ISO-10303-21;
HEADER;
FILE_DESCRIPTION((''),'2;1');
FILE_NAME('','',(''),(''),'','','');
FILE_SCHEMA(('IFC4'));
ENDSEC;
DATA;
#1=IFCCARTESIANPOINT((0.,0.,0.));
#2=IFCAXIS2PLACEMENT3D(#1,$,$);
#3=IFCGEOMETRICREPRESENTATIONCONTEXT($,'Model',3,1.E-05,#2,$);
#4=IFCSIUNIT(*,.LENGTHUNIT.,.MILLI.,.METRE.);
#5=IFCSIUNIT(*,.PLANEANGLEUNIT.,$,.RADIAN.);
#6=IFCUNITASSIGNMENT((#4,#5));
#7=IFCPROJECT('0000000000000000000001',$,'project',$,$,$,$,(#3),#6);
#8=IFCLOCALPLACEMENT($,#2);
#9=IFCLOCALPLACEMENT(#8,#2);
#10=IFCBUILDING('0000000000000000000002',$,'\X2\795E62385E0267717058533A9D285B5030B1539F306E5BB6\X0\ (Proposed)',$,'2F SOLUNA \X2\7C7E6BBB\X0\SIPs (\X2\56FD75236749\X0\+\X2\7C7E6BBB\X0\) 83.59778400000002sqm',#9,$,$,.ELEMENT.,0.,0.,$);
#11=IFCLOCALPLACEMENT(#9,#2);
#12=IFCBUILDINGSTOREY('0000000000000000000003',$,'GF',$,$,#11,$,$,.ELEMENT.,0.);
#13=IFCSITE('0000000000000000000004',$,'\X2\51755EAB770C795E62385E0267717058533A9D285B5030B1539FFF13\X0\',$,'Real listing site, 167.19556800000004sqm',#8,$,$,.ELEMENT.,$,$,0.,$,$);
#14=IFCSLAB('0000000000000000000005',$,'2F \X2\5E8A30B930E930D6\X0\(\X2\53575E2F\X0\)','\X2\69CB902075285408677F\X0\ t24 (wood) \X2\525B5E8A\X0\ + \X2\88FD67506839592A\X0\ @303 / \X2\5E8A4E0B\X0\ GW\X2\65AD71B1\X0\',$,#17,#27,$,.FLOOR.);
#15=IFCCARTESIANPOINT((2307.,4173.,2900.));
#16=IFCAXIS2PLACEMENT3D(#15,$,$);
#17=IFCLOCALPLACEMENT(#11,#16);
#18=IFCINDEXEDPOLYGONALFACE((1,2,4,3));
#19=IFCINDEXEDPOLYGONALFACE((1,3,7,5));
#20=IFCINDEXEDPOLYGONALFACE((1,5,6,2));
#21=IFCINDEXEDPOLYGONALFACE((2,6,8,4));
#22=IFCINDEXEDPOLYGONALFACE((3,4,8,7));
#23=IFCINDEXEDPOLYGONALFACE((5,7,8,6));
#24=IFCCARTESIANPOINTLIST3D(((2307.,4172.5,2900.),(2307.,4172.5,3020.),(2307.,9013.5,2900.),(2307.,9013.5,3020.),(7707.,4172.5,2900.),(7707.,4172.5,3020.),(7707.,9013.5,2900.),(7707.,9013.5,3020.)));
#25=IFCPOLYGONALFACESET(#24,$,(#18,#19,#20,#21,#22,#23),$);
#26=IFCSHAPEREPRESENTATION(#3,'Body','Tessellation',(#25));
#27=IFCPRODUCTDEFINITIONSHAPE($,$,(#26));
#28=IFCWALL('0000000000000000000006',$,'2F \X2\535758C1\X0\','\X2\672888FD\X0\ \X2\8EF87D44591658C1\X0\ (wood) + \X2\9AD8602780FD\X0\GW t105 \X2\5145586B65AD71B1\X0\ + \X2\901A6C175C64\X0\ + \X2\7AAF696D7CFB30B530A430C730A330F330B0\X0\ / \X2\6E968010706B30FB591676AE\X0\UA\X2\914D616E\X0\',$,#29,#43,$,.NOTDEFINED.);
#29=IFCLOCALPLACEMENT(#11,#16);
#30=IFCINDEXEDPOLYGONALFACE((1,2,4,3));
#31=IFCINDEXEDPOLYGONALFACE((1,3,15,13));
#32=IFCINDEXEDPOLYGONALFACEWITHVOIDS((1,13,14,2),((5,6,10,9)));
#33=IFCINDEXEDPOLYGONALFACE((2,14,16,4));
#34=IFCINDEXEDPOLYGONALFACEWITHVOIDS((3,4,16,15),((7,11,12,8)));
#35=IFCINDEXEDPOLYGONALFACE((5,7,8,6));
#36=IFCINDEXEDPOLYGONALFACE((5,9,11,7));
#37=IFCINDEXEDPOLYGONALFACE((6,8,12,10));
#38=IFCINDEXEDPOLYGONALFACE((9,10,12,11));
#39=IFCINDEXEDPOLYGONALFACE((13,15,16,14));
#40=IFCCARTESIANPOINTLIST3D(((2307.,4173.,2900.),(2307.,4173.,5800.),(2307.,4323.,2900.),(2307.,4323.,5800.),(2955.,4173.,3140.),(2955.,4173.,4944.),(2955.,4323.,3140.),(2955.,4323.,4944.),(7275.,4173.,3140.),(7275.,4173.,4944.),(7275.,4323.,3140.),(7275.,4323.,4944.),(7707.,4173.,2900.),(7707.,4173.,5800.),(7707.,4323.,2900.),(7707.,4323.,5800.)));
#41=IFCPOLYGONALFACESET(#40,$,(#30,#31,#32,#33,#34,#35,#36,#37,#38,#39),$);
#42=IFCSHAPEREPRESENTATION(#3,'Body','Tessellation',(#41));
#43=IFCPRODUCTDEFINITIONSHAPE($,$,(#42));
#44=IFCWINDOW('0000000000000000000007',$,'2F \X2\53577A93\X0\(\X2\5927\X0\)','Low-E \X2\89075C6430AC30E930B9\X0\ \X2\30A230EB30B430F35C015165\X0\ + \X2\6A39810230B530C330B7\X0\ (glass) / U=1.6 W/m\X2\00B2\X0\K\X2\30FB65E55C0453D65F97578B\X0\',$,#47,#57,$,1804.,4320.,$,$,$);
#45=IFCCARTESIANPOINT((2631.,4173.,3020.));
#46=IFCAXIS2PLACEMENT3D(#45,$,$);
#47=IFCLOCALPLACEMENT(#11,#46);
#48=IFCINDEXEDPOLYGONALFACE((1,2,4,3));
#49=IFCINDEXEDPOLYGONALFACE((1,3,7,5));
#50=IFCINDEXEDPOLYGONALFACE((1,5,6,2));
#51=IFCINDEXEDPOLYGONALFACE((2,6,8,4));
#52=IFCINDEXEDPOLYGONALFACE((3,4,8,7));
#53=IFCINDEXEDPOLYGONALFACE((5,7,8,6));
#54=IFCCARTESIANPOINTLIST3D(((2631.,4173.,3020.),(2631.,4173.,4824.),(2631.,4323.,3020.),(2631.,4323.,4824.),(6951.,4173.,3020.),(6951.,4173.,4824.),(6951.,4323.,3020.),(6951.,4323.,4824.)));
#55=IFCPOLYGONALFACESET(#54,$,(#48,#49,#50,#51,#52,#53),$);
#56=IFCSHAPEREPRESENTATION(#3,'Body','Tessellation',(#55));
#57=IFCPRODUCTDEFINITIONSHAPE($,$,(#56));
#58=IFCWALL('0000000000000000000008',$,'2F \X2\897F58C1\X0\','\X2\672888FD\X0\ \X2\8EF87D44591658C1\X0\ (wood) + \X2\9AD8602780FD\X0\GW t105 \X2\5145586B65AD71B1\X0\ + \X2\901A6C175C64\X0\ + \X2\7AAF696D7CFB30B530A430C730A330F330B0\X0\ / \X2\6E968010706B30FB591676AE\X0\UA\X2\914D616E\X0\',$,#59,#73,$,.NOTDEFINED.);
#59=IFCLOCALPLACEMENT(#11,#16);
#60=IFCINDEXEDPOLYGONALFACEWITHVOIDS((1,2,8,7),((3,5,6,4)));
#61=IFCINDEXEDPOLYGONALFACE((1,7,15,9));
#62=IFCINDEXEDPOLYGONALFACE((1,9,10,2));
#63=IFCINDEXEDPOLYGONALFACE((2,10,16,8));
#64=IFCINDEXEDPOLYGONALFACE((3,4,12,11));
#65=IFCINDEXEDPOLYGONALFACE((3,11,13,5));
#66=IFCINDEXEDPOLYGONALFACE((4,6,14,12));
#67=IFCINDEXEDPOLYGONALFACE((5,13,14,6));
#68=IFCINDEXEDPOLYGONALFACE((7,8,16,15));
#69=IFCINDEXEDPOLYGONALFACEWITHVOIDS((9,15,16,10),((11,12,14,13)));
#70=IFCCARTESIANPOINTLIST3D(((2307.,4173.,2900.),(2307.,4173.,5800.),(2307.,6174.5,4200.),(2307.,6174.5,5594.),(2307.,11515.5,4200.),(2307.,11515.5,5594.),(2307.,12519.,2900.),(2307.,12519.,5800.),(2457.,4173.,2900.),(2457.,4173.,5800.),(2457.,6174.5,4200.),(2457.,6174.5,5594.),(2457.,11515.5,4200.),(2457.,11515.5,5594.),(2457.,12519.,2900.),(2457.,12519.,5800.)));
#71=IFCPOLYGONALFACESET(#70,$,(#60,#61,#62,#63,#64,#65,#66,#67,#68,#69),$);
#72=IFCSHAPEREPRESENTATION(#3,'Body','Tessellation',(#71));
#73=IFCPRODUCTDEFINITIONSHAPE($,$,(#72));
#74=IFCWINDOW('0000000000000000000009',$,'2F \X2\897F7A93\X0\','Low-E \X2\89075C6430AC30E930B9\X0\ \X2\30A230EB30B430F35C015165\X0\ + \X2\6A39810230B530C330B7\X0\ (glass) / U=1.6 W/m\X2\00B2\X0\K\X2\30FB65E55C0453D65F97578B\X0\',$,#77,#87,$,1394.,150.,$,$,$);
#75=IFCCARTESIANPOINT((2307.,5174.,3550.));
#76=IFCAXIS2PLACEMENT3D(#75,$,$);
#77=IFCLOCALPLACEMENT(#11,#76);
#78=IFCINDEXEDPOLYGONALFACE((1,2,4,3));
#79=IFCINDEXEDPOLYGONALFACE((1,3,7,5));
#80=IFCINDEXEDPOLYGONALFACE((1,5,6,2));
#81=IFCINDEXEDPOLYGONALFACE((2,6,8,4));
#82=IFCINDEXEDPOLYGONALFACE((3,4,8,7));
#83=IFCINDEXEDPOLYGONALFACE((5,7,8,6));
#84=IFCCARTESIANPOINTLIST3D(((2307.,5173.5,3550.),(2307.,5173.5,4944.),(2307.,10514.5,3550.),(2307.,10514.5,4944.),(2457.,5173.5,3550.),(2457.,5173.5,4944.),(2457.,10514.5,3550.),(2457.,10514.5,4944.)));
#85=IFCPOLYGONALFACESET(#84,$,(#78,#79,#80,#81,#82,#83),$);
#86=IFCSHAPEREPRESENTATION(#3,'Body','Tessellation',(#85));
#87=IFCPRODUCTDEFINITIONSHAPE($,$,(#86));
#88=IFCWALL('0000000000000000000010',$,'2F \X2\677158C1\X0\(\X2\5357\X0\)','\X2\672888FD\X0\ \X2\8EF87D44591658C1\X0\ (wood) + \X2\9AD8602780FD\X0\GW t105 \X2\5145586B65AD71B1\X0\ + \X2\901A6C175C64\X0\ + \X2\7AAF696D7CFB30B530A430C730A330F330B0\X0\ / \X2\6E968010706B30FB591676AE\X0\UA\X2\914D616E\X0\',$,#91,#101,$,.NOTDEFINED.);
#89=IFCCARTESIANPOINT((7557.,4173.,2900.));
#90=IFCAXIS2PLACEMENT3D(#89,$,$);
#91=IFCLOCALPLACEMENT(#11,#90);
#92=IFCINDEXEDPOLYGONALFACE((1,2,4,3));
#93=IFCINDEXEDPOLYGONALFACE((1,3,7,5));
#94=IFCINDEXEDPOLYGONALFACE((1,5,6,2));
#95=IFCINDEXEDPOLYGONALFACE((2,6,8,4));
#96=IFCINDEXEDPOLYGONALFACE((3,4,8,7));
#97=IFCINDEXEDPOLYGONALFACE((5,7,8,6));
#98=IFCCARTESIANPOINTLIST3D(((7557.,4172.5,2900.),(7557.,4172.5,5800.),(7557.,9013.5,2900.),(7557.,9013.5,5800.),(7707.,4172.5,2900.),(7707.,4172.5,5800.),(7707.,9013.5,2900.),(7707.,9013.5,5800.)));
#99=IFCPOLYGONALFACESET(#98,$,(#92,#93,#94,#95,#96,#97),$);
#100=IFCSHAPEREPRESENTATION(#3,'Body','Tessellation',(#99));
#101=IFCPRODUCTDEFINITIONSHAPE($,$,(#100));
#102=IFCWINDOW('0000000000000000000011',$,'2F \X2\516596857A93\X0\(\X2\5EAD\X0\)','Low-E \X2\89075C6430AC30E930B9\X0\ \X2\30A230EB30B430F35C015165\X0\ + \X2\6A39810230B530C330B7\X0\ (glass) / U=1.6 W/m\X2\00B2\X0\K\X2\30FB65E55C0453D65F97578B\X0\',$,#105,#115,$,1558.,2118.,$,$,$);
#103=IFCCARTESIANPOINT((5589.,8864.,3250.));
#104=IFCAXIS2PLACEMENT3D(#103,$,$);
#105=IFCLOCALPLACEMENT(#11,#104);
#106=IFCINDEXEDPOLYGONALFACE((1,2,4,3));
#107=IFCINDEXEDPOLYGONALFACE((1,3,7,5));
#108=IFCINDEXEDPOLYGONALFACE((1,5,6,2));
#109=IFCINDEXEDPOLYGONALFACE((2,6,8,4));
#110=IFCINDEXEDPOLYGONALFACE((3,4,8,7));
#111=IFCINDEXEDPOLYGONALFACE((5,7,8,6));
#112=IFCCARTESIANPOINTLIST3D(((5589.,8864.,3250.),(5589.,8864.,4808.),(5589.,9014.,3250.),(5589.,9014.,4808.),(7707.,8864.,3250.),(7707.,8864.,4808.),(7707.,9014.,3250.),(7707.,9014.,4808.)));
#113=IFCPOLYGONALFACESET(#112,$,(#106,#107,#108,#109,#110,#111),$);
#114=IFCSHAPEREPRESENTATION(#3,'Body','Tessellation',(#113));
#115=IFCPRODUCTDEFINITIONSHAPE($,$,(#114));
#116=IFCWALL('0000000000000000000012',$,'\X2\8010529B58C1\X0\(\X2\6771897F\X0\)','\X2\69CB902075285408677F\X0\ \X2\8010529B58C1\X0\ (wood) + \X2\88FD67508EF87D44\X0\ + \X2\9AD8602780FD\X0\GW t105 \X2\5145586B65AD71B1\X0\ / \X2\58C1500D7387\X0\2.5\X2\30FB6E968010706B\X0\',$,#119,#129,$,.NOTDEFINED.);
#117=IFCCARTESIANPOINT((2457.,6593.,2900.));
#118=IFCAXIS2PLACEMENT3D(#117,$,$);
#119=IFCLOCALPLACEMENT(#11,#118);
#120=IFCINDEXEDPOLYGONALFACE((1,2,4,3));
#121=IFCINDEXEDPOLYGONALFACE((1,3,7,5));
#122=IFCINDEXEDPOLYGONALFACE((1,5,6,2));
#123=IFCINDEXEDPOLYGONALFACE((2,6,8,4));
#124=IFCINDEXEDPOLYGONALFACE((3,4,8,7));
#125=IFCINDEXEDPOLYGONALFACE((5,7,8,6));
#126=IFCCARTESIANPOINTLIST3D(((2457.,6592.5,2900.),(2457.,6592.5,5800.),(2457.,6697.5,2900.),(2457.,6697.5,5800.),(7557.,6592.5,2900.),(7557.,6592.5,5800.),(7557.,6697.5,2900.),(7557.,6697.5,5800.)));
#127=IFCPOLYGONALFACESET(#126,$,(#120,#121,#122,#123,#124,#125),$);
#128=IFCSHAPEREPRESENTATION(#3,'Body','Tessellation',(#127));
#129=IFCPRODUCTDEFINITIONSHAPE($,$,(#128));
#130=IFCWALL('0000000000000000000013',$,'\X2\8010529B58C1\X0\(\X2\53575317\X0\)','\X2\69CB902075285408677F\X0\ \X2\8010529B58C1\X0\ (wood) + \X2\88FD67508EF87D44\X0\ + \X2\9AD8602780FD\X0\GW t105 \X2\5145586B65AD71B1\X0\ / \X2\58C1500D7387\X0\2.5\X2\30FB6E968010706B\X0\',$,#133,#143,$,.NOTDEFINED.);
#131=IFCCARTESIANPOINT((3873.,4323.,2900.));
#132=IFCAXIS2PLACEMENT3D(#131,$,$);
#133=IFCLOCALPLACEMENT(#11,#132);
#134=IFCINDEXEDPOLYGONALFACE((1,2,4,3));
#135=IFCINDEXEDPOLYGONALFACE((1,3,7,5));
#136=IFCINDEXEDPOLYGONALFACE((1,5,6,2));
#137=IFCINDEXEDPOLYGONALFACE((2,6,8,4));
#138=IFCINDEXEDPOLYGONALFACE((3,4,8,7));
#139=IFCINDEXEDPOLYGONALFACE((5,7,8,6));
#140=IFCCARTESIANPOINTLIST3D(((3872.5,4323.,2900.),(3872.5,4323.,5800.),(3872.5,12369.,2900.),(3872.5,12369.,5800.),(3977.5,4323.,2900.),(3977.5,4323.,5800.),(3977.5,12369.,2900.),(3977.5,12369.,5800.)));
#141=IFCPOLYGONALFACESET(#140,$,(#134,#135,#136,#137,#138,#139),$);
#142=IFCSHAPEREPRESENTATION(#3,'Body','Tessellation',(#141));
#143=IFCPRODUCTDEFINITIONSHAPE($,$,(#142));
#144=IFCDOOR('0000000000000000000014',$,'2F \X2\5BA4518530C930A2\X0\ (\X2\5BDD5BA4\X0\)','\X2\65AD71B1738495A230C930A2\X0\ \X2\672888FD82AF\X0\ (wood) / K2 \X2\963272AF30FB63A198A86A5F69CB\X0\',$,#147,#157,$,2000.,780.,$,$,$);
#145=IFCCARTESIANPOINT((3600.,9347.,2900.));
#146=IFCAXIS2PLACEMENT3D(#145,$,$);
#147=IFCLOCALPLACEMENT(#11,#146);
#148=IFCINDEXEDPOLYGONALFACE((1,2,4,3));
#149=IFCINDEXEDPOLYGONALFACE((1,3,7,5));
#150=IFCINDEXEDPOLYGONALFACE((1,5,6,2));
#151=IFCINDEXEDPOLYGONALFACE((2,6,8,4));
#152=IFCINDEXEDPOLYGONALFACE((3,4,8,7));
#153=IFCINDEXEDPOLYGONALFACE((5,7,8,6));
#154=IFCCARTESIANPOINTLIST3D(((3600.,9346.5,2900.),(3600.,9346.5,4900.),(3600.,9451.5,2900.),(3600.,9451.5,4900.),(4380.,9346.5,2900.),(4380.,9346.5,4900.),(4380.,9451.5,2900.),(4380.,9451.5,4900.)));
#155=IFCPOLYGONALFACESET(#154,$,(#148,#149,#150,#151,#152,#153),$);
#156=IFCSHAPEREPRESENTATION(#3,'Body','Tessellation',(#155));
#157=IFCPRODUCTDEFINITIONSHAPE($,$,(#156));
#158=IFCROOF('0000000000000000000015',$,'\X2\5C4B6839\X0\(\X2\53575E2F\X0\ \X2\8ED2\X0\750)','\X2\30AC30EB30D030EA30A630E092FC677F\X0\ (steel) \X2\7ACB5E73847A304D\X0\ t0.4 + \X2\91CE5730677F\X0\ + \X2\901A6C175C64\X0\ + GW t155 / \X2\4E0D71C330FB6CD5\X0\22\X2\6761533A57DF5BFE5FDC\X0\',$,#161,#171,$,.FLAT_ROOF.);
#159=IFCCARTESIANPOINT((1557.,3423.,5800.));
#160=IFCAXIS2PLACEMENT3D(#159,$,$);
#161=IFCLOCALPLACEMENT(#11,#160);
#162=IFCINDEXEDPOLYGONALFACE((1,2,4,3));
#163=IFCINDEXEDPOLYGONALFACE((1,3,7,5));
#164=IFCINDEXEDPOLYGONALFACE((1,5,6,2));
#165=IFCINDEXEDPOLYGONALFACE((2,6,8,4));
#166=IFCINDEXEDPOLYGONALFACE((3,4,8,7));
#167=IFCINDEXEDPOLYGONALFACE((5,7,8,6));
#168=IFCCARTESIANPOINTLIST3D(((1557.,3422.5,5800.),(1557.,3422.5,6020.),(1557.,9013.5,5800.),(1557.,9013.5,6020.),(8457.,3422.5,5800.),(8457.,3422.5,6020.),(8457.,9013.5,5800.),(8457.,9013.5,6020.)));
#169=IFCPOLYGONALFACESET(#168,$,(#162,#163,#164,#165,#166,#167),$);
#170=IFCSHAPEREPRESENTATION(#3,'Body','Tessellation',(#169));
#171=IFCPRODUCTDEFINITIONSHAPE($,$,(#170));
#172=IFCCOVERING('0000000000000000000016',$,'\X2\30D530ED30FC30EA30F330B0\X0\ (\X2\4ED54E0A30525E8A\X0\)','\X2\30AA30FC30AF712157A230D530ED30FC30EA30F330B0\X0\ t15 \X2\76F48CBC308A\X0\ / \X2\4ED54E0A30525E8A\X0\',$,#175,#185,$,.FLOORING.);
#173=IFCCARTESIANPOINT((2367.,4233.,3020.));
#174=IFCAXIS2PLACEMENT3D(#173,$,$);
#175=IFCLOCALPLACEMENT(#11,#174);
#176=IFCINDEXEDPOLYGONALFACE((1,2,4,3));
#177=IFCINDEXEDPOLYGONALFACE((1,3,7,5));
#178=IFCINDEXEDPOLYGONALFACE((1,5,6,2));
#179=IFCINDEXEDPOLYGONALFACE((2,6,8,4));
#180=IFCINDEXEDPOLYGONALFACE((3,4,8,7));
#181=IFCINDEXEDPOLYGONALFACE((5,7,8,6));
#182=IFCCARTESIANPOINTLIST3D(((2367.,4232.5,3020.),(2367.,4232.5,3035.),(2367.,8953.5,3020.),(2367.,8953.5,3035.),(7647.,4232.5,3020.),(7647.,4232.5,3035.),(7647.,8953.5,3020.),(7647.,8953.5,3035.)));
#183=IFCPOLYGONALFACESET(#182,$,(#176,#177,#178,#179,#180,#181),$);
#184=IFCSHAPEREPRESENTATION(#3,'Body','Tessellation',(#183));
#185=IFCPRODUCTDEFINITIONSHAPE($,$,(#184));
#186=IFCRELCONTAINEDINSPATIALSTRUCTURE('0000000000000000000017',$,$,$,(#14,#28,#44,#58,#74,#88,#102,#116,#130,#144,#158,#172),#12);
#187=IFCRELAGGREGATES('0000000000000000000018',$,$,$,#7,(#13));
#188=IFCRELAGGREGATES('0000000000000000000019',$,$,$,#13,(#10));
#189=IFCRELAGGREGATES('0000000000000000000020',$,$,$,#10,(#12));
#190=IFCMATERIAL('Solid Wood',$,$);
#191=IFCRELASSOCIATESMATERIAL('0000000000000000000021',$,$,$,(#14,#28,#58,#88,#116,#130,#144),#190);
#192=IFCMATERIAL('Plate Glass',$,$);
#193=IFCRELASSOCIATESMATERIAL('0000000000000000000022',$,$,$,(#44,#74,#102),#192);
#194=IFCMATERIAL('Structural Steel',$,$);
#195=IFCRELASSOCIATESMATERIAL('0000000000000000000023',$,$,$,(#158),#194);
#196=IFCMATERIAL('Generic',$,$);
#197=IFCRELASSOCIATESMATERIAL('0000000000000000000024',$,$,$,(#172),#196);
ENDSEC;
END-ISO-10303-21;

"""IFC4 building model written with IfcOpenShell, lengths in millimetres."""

from ifc_helpers import new_model, si_unit, frame, frame_2d, origin, place, context, project, spatial, rectangle, extrude, material, element, fill, save


model = new_model("IFC4")

# Units and contexts
model_context = context("Model", 3, precision=1e-05, world=origin())
ifc_project = project(units=[si_unit("LENGTHUNIT", "METRE", prefix="MILLI"), si_unit("PLANEANGLEUNIT", "RADIAN")], contexts=[model_context])

# Site, building, storey
site_placement = place(None, origin())
site = spatial("IfcSite", under=ifc_project, at=site_placement, Name="兵庫県神戸市東灘区鴨子ケ原３", ObjectType="Real listing site, 167.19556800000004sqm", CompositionType="ELEMENT", RefElevation=0.0)
building_placement = place(site_placement, origin())
building = spatial("IfcBuilding", under=site, at=building_placement, Name="神戸市東灘区鴨子ケ原の家 (Proposed)", ObjectType="2F SOLUNA 籾殻SIPs (国産杉+籾殻) 83.59778400000002sqm", CompositionType="ELEMENT", ElevationOfRefHeight=0.0, ElevationOfTerrain=0.0)
storey_placement = place(building_placement, origin())
storey = spatial("IfcBuildingStorey", under=building, at=storey_placement, Name="GF", CompositionType="ELEMENT", Elevation=0.0)

# Slab
ifc_material_1 = material(Name="Solid Wood")
slab_placement = place(storey_placement, frame((2307.0, 4173.0, 2900.0)))
element("IfcSlab", 1, at=slab_placement, inside=storey, material=ifc_material_1, Name="2F 床スラブ(南帯)", Description="構造用合板 t24 (wood) 剛床 + 製材根太 @303 / 床下 GW断熱", PredefinedType="FLOOR", context=model_context, shape_type="SweptSolid", body=[
    extrude(rectangle(XDim=5400.0, YDim=4841.0, at=frame_2d((2700.0, 2420.0))), frame((2307.0, 4173.0, 2900.0)), (0.0, 0.0, 1.0), 120.0),
])

# Walls, openings, windows
wall_1_placement = place(storey_placement, frame((2307.0, 4173.0, 2900.0)))
wall_1 = element("IfcWall", 2, at=wall_1_placement, inside=storey, material=ifc_material_1, Name="2F 南壁", Description="木製 軸組外壁 (wood) + 高性能GW t105 充填断熱 + 通気層 + 窯業系サイディング / 準耐火・外皮UA配慮", PredefinedType="NOTDEFINED", context=model_context, shape_type="SweptSolid", body=[
    extrude(rectangle(XDim=5400.0, YDim=150.0, at=frame_2d((2700.0, 75.0))), frame((2307.0, 4173.0, 2900.0)), (0.0, 0.0, 1.0), 2900.0),
])
opening_1_placement = place(storey_placement, frame((2631.0, 4173.0, 3020.0)))
opening_1 = element("IfcOpeningElement", 3, at=opening_1_placement, cuts=wall_1, PredefinedType="NOTDEFINED", context=model_context, shape_type="SweptSolid", body=[
    extrude(rectangle(XDim=4320.0, YDim=150.0, at=frame_2d((2160.0, 75.0))), frame((2631.0, 4173.0, 3020.0)), (0.0, 0.0, 1.0), 1804.0),
])
ifc_material_2 = material(Name="Plate Glass")
window_1_placement = place(storey_placement, frame((2631.0, 4173.0, 3020.0)))
window_1 = element("IfcWindow", 4, at=window_1_placement, inside=storey, material=ifc_material_2, Name="2F 南窓(大)", Description="Low-E 複層ガラス アルゴン封入 + 樹脂サッシ (glass) / U=1.6 W/m²K・日射取得型", OverallHeight=1804.0, OverallWidth=4320.0, context=model_context, shape_type="SweptSolid", body=[
    extrude(rectangle(XDim=4320.0, YDim=150.0, at=frame_2d((2160.0, 75.0))), frame((2631.0, 4173.0, 3020.0)), (0.0, 0.0, 1.0), 1804.0),
])
fill(opening_1, window_1)
wall_2_placement = place(storey_placement, frame((2307.0, 4173.0, 2900.0)))
wall_2 = element("IfcWall", 5, at=wall_2_placement, inside=storey, material=ifc_material_1, Name="2F 西壁", Description="木製 軸組外壁 (wood) + 高性能GW t105 充填断熱 + 通気層 + 窯業系サイディング / 準耐火・外皮UA配慮", PredefinedType="NOTDEFINED", context=model_context, shape_type="SweptSolid", body=[
    extrude(rectangle(XDim=150.0, YDim=8346.0, at=frame_2d((75.0, 4173.0))), frame((2307.0, 4173.0, 2900.0)), (0.0, 0.0, 1.0), 2900.0),
])
opening_2_placement = place(storey_placement, frame((2307.0, 5174.0, 3550.0)))
opening_2 = element("IfcOpeningElement", 6, at=opening_2_placement, cuts=wall_2, PredefinedType="NOTDEFINED", context=model_context, shape_type="SweptSolid", body=[
    extrude(rectangle(XDim=150.0, YDim=5341.0, at=frame_2d((75.0, 2670.0))), frame((2307.0, 5174.0, 3550.0)), (0.0, 0.0, 1.0), 1394.0),
])
window_2_placement = place(storey_placement, frame((2307.0, 5174.0, 3550.0)))
window_2 = element("IfcWindow", 7, at=window_2_placement, inside=storey, material=ifc_material_2, Name="2F 西窓", Description="Low-E 複層ガラス アルゴン封入 + 樹脂サッシ (glass) / U=1.6 W/m²K・日射取得型", OverallHeight=1394.0, OverallWidth=150.0, context=model_context, shape_type="SweptSolid", body=[
    extrude(rectangle(XDim=150.0, YDim=5341.0, at=frame_2d((75.0, 2670.0))), frame((2307.0, 5174.0, 3550.0)), (0.0, 0.0, 1.0), 1394.0),
])
fill(opening_2, window_2)
wall_3_placement = place(storey_placement, frame((7557.0, 4173.0, 2900.0)))
wall_3 = element("IfcWall", 8, at=wall_3_placement, inside=storey, material=ifc_material_1, Name="2F 東壁(南)", Description="木製 軸組外壁 (wood) + 高性能GW t105 充填断熱 + 通気層 + 窯業系サイディング / 準耐火・外皮UA配慮", PredefinedType="NOTDEFINED", context=model_context, shape_type="SweptSolid", body=[
    extrude(rectangle(XDim=150.0, YDim=4841.0, at=frame_2d((75.0, 2420.0))), frame((7557.0, 4173.0, 2900.0)), (0.0, 0.0, 1.0), 2900.0),
])
opening_3_placement = place(storey_placement, frame((5589.0, 8864.0, 3250.0)))
opening_3 = element("IfcOpeningElement", 9, at=opening_3_placement, cuts=wall_3, PredefinedType="NOTDEFINED", context=model_context, shape_type="SweptSolid", body=[
    extrude(rectangle(XDim=2118.0, YDim=150.0, at=frame_2d((1059.0, 75.0))), frame((5589.0, 8864.0, 3250.0)), (0.0, 0.0, 1.0), 1558.0),
])
window_3_placement = place(storey_placement, frame((5589.0, 8864.0, 3250.0)))
window_3 = element("IfcWindow", 10, at=window_3_placement, inside=storey, material=ifc_material_2, Name="2F 入隅窓(庭)", Description="Low-E 複層ガラス アルゴン封入 + 樹脂サッシ (glass) / U=1.6 W/m²K・日射取得型", OverallHeight=1558.0, OverallWidth=2118.0, context=model_context, shape_type="SweptSolid", body=[
    extrude(rectangle(XDim=2118.0, YDim=150.0, at=frame_2d((1059.0, 75.0))), frame((5589.0, 8864.0, 3250.0)), (0.0, 0.0, 1.0), 1558.0),
])
fill(opening_3, window_3)

# Wall
wall_4_placement = place(storey_placement, frame((2457.0, 6593.0, 2900.0)))
element("IfcWall", 11, at=wall_4_placement, inside=storey, material=ifc_material_1, Name="耐力壁(東西)", Description="構造用合板 耐力壁 (wood) + 製材軸組 + 高性能GW t105 充填断熱 / 壁倍率2.5・準耐火", PredefinedType="NOTDEFINED", context=model_context, shape_type="SweptSolid", body=[
    extrude(rectangle(XDim=5100.0, YDim=105.0, at=frame_2d((2550.0, 52.0))), frame((2457.0, 6593.0, 2900.0)), (0.0, 0.0, 1.0), 2900.0),
])

# Wall, opening, door
wall_5_placement = place(storey_placement, frame((3873.0, 4323.0, 2900.0)))
wall_5 = element("IfcWall", 12, at=wall_5_placement, inside=storey, material=ifc_material_1, Name="耐力壁(南北)", Description="構造用合板 耐力壁 (wood) + 製材軸組 + 高性能GW t105 充填断熱 / 壁倍率2.5・準耐火", PredefinedType="NOTDEFINED", context=model_context, shape_type="SweptSolid", body=[
    extrude(rectangle(XDim=105.0, YDim=8046.0, at=frame_2d((52.0, 4023.0))), frame((3873.0, 4323.0, 2900.0)), (0.0, 0.0, 1.0), 2900.0),
])
opening_4_placement = place(storey_placement, frame((3600.0, 9347.0, 2900.0)))
opening_4 = element("IfcOpeningElement", 13, at=opening_4_placement, cuts=wall_5, PredefinedType="NOTDEFINED", context=model_context, shape_type="SweptSolid", body=[
    extrude(rectangle(XDim=780.0, YDim=105.0, at=frame_2d((390.0, 52.0))), frame((3600.0, 9347.0, 2900.0)), (0.0, 0.0, 1.0), 2000.0),
])
door_placement = place(storey_placement, frame((3600.0, 9347.0, 2900.0)))
door = element("IfcDoor", 14, at=door_placement, inside=storey, material=ifc_material_1, Name="2F 室内ドア (寝室)", Description="断熱玄関ドア 木製芯 (wood) / K2 防犯・採風機構", OverallHeight=2000.0, OverallWidth=780.0, context=model_context, shape_type="SweptSolid", body=[
    extrude(rectangle(XDim=780.0, YDim=105.0, at=frame_2d((390.0, 52.0))), frame((3600.0, 9347.0, 2900.0)), (0.0, 0.0, 1.0), 2000.0),
])
fill(opening_4, door)

# Roof
ifc_material_3 = material(Name="Structural Steel")
for number, where, name in (
    (15, (1557.0, 3423.0, 5800.0), "屋根(南帯 軒750)"),
):
    element("IfcRoof", number, at=place(storey_placement, frame(where)), inside=storey, material=ifc_material_3, Name=name, Description="ガルバリウム鋼板 (steel) 立平葺き t0.4 + 野地板 + 通気層 + GW t155 / 不燃・法22条区域対応", PredefinedType="FLAT_ROOF", context=model_context, shape_type="SweptSolid", body=[
        extrude(rectangle(XDim=6900.0, YDim=5591.0, at=frame_2d((3450.0, 2795.0))), frame((1557.0, 3423.0, 5800.0)), (0.0, 0.0, 1.0), 220.0),
    ])

# Covering
ifc_material_4 = material(Name="Generic")
covering_placement = place(storey_placement, frame((2367.0, 4233.0, 3020.0)))
element("IfcCovering", 16, at=covering_placement, inside=storey, material=ifc_material_4, Name="フローリング (仕上げ床)", Description="オーク無垢フローリング t15 直貼り / 仕上げ床", PredefinedType="FLOORING", context=model_context, shape_type="SweptSolid", body=[
    extrude(rectangle(XDim=5280.0, YDim=4721.0, at=frame_2d((2640.0, 2360.0))), frame((2367.0, 4233.0, 3020.0)), (0.0, 0.0, 1.0), 15.0),
])

save(model, "model.ifc")
